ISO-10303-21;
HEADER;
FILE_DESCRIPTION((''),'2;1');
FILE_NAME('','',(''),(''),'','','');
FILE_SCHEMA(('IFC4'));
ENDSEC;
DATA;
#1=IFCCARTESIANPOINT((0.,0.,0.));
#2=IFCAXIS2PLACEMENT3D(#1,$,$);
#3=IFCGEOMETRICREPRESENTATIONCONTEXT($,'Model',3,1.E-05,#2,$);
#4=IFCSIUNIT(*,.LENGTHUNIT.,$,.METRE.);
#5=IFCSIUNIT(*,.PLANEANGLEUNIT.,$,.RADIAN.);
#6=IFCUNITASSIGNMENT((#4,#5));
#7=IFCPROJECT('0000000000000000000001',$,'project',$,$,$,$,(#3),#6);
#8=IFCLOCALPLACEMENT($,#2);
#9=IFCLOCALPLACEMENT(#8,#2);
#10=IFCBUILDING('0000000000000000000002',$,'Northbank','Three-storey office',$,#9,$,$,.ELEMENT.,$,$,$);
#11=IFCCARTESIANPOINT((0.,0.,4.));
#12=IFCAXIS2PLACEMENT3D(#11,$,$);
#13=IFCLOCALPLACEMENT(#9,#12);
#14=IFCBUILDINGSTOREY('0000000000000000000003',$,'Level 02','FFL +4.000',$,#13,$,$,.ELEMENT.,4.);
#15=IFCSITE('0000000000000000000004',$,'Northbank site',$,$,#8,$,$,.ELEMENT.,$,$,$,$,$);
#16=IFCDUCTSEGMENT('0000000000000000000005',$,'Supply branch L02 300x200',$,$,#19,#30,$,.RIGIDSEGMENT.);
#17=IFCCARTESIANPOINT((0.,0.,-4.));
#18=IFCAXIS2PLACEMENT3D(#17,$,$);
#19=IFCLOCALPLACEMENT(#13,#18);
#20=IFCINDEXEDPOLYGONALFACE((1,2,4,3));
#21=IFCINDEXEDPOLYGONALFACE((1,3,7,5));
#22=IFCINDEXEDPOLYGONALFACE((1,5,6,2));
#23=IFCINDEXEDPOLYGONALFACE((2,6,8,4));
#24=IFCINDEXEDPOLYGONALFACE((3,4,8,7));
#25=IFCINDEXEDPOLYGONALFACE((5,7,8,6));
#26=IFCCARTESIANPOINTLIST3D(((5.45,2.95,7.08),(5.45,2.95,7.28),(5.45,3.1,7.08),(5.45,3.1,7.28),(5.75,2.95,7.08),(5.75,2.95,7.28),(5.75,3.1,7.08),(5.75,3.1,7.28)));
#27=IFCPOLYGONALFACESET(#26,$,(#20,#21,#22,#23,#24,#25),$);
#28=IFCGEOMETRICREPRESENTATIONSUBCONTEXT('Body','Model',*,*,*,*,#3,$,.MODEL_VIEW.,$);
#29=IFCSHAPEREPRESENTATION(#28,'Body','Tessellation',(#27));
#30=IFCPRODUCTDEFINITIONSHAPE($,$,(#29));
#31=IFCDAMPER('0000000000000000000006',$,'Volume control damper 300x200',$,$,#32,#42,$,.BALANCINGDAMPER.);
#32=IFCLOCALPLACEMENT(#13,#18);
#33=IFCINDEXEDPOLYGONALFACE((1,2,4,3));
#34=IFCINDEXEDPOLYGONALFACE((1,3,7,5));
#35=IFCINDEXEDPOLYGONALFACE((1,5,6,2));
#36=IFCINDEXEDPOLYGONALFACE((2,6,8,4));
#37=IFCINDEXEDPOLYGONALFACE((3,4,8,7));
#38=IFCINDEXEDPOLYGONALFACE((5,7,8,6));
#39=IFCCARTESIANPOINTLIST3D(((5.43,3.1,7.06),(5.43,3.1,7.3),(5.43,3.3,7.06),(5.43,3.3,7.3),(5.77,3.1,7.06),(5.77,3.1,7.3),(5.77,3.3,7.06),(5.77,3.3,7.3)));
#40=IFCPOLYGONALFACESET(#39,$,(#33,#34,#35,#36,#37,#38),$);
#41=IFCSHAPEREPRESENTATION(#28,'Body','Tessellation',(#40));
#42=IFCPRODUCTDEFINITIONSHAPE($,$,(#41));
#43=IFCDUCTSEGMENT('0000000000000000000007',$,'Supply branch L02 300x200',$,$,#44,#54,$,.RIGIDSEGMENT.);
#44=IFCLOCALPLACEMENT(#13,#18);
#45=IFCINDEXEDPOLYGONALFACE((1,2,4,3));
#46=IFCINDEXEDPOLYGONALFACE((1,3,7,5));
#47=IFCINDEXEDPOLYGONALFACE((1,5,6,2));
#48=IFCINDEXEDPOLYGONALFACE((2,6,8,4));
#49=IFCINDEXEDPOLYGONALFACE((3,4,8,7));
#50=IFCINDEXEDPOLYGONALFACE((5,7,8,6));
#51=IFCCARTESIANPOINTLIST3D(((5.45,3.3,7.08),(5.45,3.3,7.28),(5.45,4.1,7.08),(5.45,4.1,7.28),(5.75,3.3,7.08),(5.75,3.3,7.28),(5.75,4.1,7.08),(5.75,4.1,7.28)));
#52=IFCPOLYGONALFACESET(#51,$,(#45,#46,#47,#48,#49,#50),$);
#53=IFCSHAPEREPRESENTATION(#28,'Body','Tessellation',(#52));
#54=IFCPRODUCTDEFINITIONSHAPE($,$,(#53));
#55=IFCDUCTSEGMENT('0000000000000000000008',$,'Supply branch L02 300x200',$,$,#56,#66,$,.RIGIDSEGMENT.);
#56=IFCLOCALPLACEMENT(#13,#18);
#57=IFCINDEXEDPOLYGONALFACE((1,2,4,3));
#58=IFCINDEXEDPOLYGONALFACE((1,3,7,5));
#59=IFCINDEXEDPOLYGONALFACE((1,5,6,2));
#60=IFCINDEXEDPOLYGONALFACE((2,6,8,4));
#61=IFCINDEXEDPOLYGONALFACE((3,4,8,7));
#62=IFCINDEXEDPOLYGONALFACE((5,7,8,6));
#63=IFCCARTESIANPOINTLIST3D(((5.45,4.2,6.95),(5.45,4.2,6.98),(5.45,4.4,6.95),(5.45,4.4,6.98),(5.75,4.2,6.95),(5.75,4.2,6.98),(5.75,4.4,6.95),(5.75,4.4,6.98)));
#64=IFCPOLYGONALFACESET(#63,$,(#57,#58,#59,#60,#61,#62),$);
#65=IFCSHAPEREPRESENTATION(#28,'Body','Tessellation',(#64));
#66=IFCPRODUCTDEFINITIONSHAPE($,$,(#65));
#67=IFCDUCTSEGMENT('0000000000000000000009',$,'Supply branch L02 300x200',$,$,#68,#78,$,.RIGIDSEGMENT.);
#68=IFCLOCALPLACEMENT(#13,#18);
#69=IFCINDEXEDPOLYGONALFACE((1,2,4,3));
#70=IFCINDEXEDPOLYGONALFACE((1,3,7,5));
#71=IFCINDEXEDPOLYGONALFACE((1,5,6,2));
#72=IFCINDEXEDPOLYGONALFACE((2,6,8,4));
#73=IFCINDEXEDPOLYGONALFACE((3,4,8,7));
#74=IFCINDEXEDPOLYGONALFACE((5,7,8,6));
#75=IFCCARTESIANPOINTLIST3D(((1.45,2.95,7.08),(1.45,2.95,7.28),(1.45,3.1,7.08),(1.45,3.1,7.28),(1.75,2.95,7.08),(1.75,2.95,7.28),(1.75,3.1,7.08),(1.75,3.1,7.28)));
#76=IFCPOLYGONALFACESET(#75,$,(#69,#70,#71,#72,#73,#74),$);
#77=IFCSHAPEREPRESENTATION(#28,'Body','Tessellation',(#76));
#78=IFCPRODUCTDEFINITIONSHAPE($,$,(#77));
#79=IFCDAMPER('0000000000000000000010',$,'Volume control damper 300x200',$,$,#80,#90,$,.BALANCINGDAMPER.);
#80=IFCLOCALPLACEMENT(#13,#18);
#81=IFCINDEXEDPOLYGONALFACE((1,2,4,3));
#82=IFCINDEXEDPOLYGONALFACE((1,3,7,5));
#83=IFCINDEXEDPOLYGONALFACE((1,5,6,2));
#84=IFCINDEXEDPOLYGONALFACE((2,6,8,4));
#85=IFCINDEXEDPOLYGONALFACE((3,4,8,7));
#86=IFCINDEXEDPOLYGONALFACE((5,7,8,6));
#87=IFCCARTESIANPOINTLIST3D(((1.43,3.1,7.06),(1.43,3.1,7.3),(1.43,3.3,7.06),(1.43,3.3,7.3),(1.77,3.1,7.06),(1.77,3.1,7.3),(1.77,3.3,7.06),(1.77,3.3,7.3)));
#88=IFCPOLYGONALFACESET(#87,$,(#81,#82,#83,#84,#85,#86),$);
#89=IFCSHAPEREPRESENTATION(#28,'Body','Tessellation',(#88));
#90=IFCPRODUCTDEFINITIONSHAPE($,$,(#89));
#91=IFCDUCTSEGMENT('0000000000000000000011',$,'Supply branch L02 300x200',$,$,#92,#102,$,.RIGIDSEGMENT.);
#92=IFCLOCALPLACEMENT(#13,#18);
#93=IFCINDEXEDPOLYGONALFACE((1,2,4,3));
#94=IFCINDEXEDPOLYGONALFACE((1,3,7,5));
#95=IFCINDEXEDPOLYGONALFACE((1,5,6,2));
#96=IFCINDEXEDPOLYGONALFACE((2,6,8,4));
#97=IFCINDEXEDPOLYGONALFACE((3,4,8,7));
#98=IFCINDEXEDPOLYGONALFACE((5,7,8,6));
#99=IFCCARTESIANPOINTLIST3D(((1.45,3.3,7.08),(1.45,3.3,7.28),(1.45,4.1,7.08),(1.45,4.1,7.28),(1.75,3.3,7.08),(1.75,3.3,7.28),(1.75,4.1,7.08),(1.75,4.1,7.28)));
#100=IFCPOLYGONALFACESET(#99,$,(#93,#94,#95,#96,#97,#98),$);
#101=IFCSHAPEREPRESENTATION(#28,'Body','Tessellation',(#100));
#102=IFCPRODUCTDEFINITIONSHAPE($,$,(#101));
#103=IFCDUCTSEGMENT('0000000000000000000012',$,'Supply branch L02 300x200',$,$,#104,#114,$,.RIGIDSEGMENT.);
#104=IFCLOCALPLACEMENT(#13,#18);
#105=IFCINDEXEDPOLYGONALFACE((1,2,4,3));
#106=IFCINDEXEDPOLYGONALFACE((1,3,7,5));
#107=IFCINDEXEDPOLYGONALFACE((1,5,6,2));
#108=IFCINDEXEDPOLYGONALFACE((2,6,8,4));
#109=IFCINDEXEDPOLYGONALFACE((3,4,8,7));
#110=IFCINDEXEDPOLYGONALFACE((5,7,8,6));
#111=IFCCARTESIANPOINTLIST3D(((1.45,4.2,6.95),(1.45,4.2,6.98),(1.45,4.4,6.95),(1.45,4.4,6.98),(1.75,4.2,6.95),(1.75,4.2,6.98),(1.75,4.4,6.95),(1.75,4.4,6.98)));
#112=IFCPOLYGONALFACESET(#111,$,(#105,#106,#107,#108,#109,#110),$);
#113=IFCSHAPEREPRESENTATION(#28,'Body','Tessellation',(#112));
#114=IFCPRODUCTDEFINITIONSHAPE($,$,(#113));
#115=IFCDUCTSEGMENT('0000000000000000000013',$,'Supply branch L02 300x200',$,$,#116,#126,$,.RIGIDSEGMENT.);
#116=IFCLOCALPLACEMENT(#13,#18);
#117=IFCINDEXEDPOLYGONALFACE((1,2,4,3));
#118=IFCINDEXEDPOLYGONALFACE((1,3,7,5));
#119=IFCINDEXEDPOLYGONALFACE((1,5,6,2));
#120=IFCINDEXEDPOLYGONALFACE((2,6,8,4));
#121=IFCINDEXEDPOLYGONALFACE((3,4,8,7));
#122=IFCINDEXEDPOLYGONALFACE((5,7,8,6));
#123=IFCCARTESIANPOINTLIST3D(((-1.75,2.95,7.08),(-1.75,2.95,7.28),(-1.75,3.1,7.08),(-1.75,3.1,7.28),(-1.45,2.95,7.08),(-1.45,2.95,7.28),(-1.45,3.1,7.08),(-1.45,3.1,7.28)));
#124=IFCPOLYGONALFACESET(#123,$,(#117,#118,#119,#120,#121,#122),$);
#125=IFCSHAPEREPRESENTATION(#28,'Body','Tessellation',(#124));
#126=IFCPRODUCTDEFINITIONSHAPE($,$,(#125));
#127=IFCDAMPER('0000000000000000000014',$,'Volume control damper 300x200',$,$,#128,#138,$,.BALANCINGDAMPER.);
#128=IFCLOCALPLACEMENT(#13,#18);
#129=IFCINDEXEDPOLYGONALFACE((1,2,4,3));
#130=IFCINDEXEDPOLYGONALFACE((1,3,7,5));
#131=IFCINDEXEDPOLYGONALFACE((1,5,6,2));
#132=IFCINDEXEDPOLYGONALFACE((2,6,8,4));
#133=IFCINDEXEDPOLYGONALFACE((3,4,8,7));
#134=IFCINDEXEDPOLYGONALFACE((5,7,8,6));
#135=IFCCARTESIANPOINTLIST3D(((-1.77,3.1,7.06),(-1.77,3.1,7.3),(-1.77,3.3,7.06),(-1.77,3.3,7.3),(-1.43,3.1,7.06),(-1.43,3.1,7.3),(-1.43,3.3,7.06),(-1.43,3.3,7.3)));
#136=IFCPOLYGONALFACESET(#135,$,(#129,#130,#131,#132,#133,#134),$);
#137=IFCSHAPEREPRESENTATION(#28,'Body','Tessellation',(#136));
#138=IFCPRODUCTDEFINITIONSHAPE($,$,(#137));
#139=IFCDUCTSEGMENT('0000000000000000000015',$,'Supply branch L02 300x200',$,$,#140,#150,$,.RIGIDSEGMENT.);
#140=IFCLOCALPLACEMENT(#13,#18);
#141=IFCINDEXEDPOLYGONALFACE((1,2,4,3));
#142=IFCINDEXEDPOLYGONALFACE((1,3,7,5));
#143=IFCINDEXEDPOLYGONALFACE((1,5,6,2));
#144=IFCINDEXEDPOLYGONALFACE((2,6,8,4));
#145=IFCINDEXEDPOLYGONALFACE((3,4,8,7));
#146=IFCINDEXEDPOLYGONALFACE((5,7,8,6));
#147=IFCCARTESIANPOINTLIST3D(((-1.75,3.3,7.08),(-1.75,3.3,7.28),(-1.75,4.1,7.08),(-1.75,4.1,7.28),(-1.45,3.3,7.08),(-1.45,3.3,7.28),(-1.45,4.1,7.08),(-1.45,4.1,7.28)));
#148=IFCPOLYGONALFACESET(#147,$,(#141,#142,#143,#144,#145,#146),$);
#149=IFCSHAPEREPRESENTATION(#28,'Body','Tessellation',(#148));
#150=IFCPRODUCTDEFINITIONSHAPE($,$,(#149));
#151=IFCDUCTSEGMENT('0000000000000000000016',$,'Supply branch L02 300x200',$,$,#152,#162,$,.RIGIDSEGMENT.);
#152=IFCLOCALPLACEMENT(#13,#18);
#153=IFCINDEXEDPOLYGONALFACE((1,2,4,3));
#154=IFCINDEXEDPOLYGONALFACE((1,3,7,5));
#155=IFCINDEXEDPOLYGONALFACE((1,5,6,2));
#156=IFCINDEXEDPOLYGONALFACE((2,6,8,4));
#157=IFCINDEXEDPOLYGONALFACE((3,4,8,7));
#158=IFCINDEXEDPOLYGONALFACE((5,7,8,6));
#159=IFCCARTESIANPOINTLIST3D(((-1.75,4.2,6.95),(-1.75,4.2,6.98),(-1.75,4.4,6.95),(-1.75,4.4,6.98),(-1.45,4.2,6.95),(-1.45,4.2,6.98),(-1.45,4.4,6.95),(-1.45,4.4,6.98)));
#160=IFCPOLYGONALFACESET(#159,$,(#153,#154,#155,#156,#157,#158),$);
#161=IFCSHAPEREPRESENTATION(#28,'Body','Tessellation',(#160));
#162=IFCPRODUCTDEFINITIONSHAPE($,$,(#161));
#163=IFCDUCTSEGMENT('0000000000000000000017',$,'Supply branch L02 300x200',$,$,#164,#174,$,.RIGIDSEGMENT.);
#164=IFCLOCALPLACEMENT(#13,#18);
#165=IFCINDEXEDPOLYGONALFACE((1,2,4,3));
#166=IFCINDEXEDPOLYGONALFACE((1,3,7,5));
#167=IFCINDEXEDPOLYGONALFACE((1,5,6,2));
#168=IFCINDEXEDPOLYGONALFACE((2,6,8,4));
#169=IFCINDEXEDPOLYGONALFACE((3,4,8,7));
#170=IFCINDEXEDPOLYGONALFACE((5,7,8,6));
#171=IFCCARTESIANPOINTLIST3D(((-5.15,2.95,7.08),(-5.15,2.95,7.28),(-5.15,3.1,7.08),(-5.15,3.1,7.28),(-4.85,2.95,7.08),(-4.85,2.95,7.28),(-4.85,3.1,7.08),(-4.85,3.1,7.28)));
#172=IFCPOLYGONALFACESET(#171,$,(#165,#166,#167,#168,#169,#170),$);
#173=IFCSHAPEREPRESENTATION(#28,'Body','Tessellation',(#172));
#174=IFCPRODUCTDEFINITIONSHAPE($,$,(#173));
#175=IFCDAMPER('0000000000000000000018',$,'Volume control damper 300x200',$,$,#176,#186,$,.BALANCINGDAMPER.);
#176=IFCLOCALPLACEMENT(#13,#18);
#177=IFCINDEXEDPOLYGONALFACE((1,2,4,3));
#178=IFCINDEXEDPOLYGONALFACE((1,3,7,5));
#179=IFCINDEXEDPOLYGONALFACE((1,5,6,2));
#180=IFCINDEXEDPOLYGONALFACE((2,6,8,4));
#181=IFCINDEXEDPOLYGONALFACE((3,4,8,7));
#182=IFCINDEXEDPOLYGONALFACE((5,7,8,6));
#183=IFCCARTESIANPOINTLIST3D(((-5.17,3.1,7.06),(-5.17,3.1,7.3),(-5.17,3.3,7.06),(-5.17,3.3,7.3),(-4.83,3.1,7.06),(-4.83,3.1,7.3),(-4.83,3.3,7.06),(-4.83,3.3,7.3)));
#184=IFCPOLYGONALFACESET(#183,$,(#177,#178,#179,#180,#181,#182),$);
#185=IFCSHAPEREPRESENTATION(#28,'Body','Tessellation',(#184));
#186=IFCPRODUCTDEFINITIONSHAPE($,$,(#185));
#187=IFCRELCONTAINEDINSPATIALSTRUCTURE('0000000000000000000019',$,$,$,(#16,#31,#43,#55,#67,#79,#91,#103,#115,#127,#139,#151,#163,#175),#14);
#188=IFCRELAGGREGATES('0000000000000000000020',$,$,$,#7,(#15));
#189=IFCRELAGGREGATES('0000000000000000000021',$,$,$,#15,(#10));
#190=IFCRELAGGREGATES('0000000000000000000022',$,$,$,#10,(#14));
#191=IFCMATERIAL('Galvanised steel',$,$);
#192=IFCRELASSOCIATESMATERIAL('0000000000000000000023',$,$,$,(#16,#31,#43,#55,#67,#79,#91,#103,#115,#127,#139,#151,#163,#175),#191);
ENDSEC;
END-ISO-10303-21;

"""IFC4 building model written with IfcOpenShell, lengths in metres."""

from ifc_helpers import new_model, si_unit, frame, origin, place, context, subcontext, project, spatial, rectangle, extrude, material, element, save


model = new_model("IFC4")

# Units and contexts
model_context = context("Model", 3, precision=1e-05, world=origin())
body_context = subcontext(model_context, "Body", "Model", "MODEL_VIEW")
ifc_project = project(units=[si_unit("LENGTHUNIT", "METRE"), si_unit("PLANEANGLEUNIT", "RADIAN")], contexts=[model_context])

# Site, building, storey
site_placement = place(None, origin())
site = spatial("IfcSite", under=ifc_project, at=site_placement, Name="Northbank site", CompositionType="ELEMENT")
building_placement = place(site_placement, origin())
building = spatial("IfcBuilding", under=site, at=building_placement, Name="Northbank", Description="Three-storey office", CompositionType="ELEMENT")
storey_placement = place(building_placement, frame((0.0, 0.0, 4.0)))
storey = spatial("IfcBuildingStorey", under=building, at=storey_placement, Name="Level 02", Description="FFL +4.000", CompositionType="ELEMENT", Elevation=4.0)

# Duct segment
ifc_material_1 = material(Name="Galvanised steel")
duct_segment_1_placement = place(storey_placement, frame((0.0, 0.0, -4.0)))
element("IfcDuctSegment", 1, at=duct_segment_1_placement, inside=storey, material=ifc_material_1, Name="Supply branch L02 300x200", PredefinedType="RIGIDSEGMENT", context=body_context, shape_type="SweptSolid", body=[
    extrude(rectangle(XDim=0.3, YDim=0.2), frame((5.6, 2.95, 7.18), z_axis=(0.0, 1.0, 0.0), x_axis=(-1.0, 0.0, 0.0)), (0.0, 0.0, 1.0), 0.15),
])

# Damper
damper_1_placement = place(storey_placement, frame((0.0, 0.0, -4.0)))
element("IfcDamper", 2, at=damper_1_placement, inside=storey, material=ifc_material_1, Name="Volume control damper 300x200", PredefinedType="BALANCINGDAMPER", context=body_context, shape_type="SweptSolid", body=[
    extrude(rectangle(XDim=0.34, YDim=0.24), frame((5.6, 3.1, 7.18), z_axis=(0.0, 1.0, 0.0), x_axis=(-1.0, 0.0, 0.0)), (0.0, 0.0, 1.0), 0.2),
])

# Duct segments
duct_segment_2_placement = place(storey_placement, frame((0.0, 0.0, -4.0)))
element("IfcDuctSegment", 3, at=duct_segment_2_placement, inside=storey, material=ifc_material_1, Name="Supply branch L02 300x200", PredefinedType="RIGIDSEGMENT", context=body_context, shape_type="SweptSolid", body=[
    extrude(rectangle(XDim=0.3, YDim=0.2), frame((5.6, 3.3, 7.18), z_axis=(0.0, 1.0, 0.0), x_axis=(-1.0, 0.0, 0.0)), (0.0, 0.0, 1.0), 0.8),
])
duct_segment_3_placement = place(storey_placement, frame((0.0, 0.0, -4.0)))
element("IfcDuctSegment", 4, at=duct_segment_3_placement, inside=storey, material=ifc_material_1, Name="Supply branch L02 300x200", PredefinedType="RIGIDSEGMENT", context=body_context, shape_type="SweptSolid", body=[
    extrude(rectangle(XDim=0.3, YDim=0.2), frame((5.6, 4.3, 6.98), z_axis=(0.0, 0.0, -1.0), x_axis=(-1.0, 0.0, 0.0)), (0.0, 0.0, 1.0), 0.03),
])

# Duct segment
duct_segment_4_placement = place(storey_placement, frame((0.0, 0.0, -4.0)))
element("IfcDuctSegment", 5, at=duct_segment_4_placement, inside=storey, material=ifc_material_1, Name="Supply branch L02 300x200", PredefinedType="RIGIDSEGMENT", context=body_context, shape_type="SweptSolid", body=[
    extrude(rectangle(XDim=0.3, YDim=0.2), frame((1.6, 2.95, 7.18), z_axis=(0.0, 1.0, 0.0), x_axis=(-1.0, 0.0, 0.0)), (0.0, 0.0, 1.0), 0.15),
])

# Damper
damper_2_placement = place(storey_placement, frame((0.0, 0.0, -4.0)))
element("IfcDamper", 6, at=damper_2_placement, inside=storey, material=ifc_material_1, Name="Volume control damper 300x200", PredefinedType="BALANCINGDAMPER", context=body_context, shape_type="SweptSolid", body=[
    extrude(rectangle(XDim=0.34, YDim=0.24), frame((1.6, 3.1, 7.18), z_axis=(0.0, 1.0, 0.0), x_axis=(-1.0, 0.0, 0.0)), (0.0, 0.0, 1.0), 0.2),
])

# Duct segments
duct_segment_5_placement = place(storey_placement, frame((0.0, 0.0, -4.0)))
element("IfcDuctSegment", 7, at=duct_segment_5_placement, inside=storey, material=ifc_material_1, Name="Supply branch L02 300x200", PredefinedType="RIGIDSEGMENT", context=body_context, shape_type="SweptSolid", body=[
    extrude(rectangle(XDim=0.3, YDim=0.2), frame((1.6, 3.3, 7.18), z_axis=(0.0, 1.0, 0.0), x_axis=(-1.0, 0.0, 0.0)), (0.0, 0.0, 1.0), 0.8),
])
duct_segment_6_placement = place(storey_placement, frame((0.0, 0.0, -4.0)))
element("IfcDuctSegment", 8, at=duct_segment_6_placement, inside=storey, material=ifc_material_1, Name="Supply branch L02 300x200", PredefinedType="RIGIDSEGMENT", context=body_context, shape_type="SweptSolid", body=[
    extrude(rectangle(XDim=0.3, YDim=0.2), frame((1.6, 4.3, 6.98), z_axis=(0.0, 0.0, -1.0), x_axis=(-1.0, 0.0, 0.0)), (0.0, 0.0, 1.0), 0.03),
])

# Duct segment
duct_segment_7_placement = place(storey_placement, frame((0.0, 0.0, -4.0)))
element("IfcDuctSegment", 9, at=duct_segment_7_placement, inside=storey, material=ifc_material_1, Name="Supply branch L02 300x200", PredefinedType="RIGIDSEGMENT", context=body_context, shape_type="SweptSolid", body=[
    extrude(rectangle(XDim=0.3, YDim=0.2), frame((-1.6, 2.95, 7.18), z_axis=(0.0, 1.0, 0.0), x_axis=(-1.0, 0.0, 0.0)), (0.0, 0.0, 1.0), 0.15),
])

# Damper
damper_3_placement = place(storey_placement, frame((0.0, 0.0, -4.0)))
element("IfcDamper", 10, at=damper_3_placement, inside=storey, material=ifc_material_1, Name="Volume control damper 300x200", PredefinedType="BALANCINGDAMPER", context=body_context, shape_type="SweptSolid", body=[
    extrude(rectangle(XDim=0.34, YDim=0.24), frame((-1.6, 3.1, 7.18), z_axis=(0.0, 1.0, 0.0), x_axis=(-1.0, 0.0, 0.0)), (0.0, 0.0, 1.0), 0.2),
])

# Duct segments
duct_segment_8_placement = place(storey_placement, frame((0.0, 0.0, -4.0)))
element("IfcDuctSegment", 11, at=duct_segment_8_placement, inside=storey, material=ifc_material_1, Name="Supply branch L02 300x200", PredefinedType="RIGIDSEGMENT", context=body_context, shape_type="SweptSolid", body=[
    extrude(rectangle(XDim=0.3, YDim=0.2), frame((-1.6, 3.3, 7.18), z_axis=(0.0, 1.0, 0.0), x_axis=(-1.0, 0.0, 0.0)), (0.0, 0.0, 1.0), 0.8),
])
duct_segment_9_placement = place(storey_placement, frame((0.0, 0.0, -4.0)))
element("IfcDuctSegment", 12, at=duct_segment_9_placement, inside=storey, material=ifc_material_1, Name="Supply branch L02 300x200", PredefinedType="RIGIDSEGMENT", context=body_context, shape_type="SweptSolid", body=[
    extrude(rectangle(XDim=0.3, YDim=0.2), frame((-1.6, 4.3, 6.98), z_axis=(0.0, 0.0, -1.0), x_axis=(-1.0, 0.0, 0.0)), (0.0, 0.0, 1.0), 0.03),
])

# Duct segment
duct_segment_10_placement = place(storey_placement, frame((0.0, 0.0, -4.0)))
element("IfcDuctSegment", 13, at=duct_segment_10_placement, inside=storey, material=ifc_material_1, Name="Supply branch L02 300x200", PredefinedType="RIGIDSEGMENT", context=body_context, shape_type="SweptSolid", body=[
    extrude(rectangle(XDim=0.3, YDim=0.2), frame((-5.0, 2.95, 7.18), z_axis=(0.0, 1.0, 0.0), x_axis=(-1.0, 0.0, 0.0)), (0.0, 0.0, 1.0), 0.15),
])

# Damper
damper_4_placement = place(storey_placement, frame((0.0, 0.0, -4.0)))
element("IfcDamper", 14, at=damper_4_placement, inside=storey, material=ifc_material_1, Name="Volume control damper 300x200", PredefinedType="BALANCINGDAMPER", context=body_context, shape_type="SweptSolid", body=[
    extrude(rectangle(XDim=0.34, YDim=0.24), frame((-5.0, 3.1, 7.18), z_axis=(0.0, 1.0, 0.0), x_axis=(-1.0, 0.0, 0.0)), (0.0, 0.0, 1.0), 0.2),
])

save(model, "model.ifc")
